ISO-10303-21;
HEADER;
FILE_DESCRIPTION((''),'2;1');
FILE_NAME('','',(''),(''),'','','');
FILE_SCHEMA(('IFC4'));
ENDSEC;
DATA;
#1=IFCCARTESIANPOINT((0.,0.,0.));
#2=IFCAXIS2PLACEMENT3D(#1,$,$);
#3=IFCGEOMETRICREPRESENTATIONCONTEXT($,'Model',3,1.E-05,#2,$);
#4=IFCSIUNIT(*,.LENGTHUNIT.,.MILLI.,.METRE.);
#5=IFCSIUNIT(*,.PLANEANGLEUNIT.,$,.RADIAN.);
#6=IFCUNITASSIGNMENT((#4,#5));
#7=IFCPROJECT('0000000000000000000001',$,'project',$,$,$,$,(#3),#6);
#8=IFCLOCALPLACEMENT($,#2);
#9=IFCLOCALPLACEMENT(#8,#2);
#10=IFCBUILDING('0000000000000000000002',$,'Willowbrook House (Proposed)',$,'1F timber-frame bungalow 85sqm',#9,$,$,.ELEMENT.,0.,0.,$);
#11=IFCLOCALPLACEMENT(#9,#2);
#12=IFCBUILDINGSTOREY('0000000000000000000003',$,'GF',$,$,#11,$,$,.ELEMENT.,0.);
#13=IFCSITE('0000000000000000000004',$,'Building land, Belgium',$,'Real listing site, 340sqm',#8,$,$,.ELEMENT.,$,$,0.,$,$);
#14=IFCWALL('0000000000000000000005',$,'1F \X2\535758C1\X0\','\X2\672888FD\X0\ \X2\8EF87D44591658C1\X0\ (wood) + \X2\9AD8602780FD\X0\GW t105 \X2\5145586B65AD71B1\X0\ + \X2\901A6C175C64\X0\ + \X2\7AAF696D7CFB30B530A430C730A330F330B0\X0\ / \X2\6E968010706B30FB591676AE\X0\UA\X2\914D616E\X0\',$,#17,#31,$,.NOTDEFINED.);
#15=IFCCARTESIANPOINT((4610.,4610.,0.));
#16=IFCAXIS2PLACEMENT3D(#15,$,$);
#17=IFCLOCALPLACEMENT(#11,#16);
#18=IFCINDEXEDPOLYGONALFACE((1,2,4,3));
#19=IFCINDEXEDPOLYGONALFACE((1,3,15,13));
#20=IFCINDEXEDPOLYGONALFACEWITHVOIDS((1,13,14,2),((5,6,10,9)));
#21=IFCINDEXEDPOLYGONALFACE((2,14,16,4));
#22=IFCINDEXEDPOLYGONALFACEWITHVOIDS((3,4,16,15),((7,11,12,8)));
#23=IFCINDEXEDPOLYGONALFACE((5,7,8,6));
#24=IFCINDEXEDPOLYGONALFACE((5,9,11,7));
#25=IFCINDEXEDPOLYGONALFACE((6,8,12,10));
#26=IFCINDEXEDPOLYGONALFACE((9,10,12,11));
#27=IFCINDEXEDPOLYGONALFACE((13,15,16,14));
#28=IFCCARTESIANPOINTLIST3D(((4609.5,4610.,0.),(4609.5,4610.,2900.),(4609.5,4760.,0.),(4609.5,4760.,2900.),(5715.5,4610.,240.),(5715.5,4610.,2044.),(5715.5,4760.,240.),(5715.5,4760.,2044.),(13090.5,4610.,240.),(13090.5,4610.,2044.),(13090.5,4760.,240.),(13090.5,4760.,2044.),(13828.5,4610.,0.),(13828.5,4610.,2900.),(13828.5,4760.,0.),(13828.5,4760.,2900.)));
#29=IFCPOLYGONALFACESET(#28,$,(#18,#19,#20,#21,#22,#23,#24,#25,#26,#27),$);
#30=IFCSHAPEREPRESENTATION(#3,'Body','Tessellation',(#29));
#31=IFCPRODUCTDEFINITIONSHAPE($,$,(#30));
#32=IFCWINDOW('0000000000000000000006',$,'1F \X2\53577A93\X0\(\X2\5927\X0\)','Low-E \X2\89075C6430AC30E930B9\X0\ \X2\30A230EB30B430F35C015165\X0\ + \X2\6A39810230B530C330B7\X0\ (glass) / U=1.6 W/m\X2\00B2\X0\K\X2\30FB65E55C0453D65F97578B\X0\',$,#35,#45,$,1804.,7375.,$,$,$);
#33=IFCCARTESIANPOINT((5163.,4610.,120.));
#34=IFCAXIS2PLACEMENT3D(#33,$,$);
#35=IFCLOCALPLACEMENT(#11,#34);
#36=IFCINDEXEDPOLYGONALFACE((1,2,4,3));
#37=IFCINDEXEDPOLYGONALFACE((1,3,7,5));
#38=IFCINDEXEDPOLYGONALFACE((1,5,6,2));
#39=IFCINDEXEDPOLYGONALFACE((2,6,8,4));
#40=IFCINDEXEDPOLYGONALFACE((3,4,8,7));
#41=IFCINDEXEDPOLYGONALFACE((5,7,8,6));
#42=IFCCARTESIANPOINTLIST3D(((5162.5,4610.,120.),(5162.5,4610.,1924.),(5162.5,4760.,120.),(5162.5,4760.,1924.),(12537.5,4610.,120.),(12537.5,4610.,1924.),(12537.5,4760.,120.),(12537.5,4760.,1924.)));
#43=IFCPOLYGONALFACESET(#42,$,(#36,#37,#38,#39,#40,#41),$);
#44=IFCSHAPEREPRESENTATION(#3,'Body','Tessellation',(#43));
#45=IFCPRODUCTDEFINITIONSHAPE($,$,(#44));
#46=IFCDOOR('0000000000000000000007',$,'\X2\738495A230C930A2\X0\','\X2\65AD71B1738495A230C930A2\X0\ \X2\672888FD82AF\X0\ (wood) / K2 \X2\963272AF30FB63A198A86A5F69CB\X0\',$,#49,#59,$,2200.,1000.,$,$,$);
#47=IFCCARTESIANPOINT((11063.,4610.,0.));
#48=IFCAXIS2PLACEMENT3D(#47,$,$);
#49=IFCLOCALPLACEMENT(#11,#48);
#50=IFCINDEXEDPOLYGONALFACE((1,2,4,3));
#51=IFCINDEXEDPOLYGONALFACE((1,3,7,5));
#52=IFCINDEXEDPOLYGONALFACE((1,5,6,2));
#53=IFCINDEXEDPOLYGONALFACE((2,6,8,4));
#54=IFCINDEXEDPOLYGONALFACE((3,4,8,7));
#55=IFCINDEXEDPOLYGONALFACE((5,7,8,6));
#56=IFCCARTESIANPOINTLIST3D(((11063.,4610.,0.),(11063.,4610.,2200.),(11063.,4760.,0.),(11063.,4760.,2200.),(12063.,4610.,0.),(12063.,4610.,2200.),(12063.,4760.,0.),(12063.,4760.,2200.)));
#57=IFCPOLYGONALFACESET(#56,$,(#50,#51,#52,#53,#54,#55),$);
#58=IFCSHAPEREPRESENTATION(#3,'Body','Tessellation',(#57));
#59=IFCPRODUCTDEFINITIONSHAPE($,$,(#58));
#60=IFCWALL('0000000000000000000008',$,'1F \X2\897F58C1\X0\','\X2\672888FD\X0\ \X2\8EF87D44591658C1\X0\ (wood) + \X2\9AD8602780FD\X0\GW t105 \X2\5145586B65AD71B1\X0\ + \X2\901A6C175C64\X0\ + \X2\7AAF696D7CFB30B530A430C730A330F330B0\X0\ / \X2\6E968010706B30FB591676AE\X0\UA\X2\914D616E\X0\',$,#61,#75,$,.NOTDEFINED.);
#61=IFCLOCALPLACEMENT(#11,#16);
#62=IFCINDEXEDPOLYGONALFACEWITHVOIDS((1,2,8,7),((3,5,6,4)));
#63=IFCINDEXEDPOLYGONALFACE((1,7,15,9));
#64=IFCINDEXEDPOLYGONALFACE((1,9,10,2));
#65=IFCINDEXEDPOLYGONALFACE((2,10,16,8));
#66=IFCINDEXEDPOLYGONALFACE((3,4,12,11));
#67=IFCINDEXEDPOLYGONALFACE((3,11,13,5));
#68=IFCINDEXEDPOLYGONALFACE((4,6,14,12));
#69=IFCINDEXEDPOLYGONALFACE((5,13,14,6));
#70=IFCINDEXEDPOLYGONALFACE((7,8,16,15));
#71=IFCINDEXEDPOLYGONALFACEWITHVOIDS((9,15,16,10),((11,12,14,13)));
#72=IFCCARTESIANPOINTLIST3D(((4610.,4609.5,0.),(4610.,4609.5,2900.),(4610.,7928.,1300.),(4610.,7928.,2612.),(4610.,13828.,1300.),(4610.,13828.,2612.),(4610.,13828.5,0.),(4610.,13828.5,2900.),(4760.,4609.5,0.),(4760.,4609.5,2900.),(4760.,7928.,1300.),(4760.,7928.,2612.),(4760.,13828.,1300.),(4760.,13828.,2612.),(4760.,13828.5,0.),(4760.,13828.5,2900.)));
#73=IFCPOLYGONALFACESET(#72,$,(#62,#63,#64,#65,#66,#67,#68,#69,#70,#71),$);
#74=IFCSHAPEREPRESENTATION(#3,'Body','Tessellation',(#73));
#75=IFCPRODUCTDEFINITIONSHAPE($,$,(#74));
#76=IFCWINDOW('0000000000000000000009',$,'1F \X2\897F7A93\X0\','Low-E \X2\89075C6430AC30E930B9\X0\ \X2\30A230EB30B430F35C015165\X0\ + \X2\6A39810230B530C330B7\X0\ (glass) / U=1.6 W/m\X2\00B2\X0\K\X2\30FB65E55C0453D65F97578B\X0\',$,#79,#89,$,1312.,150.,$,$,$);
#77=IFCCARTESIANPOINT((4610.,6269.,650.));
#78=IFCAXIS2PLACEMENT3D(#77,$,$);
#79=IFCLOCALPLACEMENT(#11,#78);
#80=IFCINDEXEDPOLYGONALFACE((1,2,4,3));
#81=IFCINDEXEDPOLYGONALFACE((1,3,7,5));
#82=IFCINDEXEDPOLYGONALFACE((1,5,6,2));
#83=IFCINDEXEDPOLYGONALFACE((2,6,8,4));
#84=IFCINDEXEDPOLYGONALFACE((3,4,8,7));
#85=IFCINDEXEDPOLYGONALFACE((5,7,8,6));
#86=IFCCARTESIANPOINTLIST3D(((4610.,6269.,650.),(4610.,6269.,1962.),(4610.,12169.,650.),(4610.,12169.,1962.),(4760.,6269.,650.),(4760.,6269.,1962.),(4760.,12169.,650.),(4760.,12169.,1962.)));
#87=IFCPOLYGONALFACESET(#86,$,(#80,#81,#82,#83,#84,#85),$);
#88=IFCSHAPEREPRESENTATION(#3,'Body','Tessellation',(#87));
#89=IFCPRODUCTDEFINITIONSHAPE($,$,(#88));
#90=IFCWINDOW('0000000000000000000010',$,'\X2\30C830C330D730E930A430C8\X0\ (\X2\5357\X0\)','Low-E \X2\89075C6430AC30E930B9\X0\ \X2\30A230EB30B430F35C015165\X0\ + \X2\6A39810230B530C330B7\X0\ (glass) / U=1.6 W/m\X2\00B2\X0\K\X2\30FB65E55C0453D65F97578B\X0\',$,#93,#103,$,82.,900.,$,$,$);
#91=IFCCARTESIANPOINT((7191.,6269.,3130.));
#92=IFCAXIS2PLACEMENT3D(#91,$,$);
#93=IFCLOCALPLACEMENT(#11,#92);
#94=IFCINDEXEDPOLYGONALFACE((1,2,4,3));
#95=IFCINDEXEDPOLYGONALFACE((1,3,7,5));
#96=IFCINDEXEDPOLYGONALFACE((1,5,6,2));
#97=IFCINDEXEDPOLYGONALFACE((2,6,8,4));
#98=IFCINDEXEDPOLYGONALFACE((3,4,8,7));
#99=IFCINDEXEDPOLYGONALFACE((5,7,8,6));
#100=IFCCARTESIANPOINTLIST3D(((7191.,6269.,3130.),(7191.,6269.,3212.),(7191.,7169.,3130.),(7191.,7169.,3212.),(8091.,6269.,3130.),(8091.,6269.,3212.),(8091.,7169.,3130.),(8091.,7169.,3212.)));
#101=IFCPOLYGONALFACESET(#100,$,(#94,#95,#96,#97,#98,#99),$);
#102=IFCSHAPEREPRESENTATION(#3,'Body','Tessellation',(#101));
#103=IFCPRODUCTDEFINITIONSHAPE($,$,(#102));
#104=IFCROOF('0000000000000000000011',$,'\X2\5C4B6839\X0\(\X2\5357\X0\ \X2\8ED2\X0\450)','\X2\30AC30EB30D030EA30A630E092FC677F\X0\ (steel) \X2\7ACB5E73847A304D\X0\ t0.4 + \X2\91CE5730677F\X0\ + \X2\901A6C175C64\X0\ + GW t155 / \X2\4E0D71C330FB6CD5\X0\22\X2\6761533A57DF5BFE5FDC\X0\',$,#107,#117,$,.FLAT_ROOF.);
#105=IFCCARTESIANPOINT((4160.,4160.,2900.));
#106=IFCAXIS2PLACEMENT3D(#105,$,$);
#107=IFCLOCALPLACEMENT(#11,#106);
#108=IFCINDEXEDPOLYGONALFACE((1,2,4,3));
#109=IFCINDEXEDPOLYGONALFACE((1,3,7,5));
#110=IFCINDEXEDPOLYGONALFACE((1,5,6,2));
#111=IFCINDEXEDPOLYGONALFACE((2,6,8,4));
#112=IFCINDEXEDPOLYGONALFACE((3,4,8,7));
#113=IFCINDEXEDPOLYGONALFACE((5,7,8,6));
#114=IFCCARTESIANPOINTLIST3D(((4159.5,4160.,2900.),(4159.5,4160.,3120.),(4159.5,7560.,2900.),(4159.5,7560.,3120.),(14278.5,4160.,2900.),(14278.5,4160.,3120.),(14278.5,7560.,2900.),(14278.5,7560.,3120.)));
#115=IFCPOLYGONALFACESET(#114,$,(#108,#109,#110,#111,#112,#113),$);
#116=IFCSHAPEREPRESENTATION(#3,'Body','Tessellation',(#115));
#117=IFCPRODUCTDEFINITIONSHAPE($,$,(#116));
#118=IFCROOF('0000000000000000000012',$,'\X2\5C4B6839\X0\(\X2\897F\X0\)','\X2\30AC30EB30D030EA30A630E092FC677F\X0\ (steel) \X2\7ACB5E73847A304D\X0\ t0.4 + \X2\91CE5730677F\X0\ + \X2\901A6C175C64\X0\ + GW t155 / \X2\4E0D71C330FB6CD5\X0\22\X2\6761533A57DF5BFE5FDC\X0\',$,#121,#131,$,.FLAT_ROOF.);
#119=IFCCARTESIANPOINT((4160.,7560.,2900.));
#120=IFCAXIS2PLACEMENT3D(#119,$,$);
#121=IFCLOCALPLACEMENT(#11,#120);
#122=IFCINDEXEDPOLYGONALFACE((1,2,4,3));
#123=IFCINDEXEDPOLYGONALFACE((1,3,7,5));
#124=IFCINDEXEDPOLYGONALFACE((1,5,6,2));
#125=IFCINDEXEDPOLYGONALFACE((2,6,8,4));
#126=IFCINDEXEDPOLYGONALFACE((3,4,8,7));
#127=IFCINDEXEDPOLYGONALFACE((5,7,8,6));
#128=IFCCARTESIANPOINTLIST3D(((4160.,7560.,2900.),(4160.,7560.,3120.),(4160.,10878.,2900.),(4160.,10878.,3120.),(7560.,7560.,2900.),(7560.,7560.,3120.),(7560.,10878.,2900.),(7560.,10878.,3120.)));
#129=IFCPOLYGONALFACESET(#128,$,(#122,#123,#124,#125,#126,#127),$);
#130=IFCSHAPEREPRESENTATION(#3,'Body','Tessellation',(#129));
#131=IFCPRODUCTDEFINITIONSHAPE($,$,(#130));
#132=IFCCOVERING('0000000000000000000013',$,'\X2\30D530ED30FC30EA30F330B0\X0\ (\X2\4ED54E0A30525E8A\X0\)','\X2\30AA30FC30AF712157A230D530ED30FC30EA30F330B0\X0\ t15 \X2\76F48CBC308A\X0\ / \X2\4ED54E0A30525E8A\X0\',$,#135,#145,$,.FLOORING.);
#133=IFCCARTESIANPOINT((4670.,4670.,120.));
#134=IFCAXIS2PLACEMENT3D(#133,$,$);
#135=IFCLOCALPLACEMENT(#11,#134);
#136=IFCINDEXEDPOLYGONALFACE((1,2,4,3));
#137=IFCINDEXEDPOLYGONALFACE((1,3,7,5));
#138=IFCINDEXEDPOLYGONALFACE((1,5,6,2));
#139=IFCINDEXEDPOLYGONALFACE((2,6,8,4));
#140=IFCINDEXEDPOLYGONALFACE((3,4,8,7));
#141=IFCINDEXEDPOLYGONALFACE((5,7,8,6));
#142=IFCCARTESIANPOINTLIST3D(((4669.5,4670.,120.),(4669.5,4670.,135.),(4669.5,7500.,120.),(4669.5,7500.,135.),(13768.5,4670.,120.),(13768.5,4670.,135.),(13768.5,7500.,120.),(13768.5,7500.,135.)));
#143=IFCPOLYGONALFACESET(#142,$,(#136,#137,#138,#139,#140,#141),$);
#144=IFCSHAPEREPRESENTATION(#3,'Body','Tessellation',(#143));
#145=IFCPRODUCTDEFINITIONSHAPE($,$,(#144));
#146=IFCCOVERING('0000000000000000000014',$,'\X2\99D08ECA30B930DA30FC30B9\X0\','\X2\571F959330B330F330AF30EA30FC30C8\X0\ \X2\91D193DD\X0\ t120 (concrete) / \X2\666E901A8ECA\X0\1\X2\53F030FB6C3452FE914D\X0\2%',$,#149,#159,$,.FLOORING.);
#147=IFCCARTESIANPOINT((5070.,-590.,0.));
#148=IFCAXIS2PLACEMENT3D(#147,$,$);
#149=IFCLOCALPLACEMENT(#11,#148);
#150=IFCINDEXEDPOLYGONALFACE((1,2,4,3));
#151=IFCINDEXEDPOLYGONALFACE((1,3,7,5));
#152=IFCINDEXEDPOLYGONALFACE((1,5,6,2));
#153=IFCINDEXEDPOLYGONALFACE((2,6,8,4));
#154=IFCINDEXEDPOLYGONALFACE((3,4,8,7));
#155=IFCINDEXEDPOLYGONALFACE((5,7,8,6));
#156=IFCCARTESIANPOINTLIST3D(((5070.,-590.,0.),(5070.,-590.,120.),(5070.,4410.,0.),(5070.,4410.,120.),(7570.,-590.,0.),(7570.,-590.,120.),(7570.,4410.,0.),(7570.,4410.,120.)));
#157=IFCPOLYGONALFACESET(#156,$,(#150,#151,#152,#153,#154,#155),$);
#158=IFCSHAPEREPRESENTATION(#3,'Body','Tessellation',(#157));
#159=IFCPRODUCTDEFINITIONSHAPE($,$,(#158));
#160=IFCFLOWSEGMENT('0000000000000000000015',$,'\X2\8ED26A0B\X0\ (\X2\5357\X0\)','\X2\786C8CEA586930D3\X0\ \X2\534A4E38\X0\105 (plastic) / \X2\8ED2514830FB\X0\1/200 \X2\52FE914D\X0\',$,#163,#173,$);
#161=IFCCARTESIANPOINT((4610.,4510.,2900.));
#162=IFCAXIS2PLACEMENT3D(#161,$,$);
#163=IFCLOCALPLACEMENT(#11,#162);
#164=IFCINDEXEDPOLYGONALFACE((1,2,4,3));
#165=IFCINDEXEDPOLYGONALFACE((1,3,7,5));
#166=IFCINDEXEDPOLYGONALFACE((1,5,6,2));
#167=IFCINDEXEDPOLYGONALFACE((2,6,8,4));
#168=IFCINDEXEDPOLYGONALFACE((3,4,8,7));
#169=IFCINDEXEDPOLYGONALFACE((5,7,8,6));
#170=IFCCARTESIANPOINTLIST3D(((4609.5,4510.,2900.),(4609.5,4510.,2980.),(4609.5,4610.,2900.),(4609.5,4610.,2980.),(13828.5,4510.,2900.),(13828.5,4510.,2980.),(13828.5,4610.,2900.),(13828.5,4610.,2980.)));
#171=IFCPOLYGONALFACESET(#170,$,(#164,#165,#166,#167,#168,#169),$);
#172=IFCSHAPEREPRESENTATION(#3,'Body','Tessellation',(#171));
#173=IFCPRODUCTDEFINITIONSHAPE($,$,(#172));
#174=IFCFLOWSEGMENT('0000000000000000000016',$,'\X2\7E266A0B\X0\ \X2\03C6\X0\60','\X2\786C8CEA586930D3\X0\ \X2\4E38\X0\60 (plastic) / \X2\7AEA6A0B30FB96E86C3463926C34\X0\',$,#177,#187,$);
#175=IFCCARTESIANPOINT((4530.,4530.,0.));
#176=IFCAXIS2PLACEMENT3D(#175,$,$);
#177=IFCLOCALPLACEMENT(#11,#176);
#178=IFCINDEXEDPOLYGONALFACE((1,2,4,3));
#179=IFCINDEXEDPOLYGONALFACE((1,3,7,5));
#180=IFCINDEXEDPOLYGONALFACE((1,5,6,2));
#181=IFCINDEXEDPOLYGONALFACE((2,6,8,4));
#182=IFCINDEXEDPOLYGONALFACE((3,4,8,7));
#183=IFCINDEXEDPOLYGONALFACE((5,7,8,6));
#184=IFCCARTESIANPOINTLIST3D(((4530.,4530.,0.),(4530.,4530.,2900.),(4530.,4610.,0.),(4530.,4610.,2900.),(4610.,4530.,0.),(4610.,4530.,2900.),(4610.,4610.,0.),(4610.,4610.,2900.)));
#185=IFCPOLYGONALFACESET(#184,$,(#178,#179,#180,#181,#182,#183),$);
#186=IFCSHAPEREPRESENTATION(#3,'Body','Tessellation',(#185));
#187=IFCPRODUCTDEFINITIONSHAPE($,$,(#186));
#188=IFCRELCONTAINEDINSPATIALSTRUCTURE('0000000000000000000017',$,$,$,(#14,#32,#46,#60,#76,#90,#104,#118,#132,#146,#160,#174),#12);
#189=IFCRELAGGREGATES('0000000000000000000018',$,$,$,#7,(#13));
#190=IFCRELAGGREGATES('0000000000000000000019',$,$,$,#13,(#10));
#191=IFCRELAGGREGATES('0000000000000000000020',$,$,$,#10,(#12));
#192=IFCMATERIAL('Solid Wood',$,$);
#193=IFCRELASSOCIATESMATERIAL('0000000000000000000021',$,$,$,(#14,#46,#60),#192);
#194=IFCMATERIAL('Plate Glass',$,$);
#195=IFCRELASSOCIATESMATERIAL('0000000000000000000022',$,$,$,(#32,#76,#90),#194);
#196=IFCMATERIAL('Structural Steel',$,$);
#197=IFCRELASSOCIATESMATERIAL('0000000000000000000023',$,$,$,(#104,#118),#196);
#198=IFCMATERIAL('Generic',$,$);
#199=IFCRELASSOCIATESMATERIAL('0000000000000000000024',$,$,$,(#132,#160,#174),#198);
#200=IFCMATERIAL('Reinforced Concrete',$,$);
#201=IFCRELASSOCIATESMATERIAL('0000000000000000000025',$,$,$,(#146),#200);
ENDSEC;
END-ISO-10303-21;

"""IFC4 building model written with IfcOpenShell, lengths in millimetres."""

from ifc_helpers import new_model, si_unit, frame, frame_2d, origin, place, context, project, spatial, rectangle, extrude, material, element, fill, save


model = new_model("IFC4")

# Units and contexts
model_context = context("Model", 3, precision=1e-05, world=origin())
ifc_project = project(units=[si_unit("LENGTHUNIT", "METRE", prefix="MILLI"), si_unit("PLANEANGLEUNIT", "RADIAN")], contexts=[model_context])

# Site, building, storey
site_placement = place(None, origin())
site = spatial("IfcSite", under=ifc_project, at=site_placement, Name="Building land, Belgium", ObjectType="Real listing site, 340sqm", CompositionType="ELEMENT", RefElevation=0.0)
building_placement = place(site_placement, origin())
building = spatial("IfcBuilding", under=site, at=building_placement, Name="Willowbrook House (Proposed)", ObjectType="1F timber-frame bungalow 85sqm", CompositionType="ELEMENT", ElevationOfRefHeight=0.0, ElevationOfTerrain=0.0)
storey_placement = place(building_placement, origin())
storey = spatial("IfcBuildingStorey", under=building, at=storey_placement, Name="GF", CompositionType="ELEMENT", Elevation=0.0)

# Shared definitions
ifc_material_1 = material(Name="Solid Wood")

# Shared definitions
ifc_material_2 = material(Name="Reinforced Concrete")

# Wall, openings, window, door
wall_1_placement = place(storey_placement, frame((4610.0, 4610.0, 0.0)))
wall_1 = element("IfcWall", 1, at=wall_1_placement, inside=storey, material=ifc_material_1, Name="1F 南壁", Description="木製 軸組外壁 (wood) + 高性能GW t105 充填断熱 + 通気層 + 窯業系サイディング / 準耐火・外皮UA配慮", PredefinedType="NOTDEFINED", context=model_context, shape_type="SweptSolid", body=[
    extrude(rectangle(XDim=9219.0, YDim=150.0, at=frame_2d((4609.0, 75.0))), frame((4610.0, 4610.0, 0.0)), (0.0, 0.0, 1.0), 2900.0),
])
opening_1_placement = place(storey_placement, frame((5163.0, 4610.0, 120.0)))
opening_1 = element("IfcOpeningElement", 2, at=opening_1_placement, cuts=wall_1, PredefinedType="NOTDEFINED", context=model_context, shape_type="SweptSolid", body=[
    extrude(rectangle(XDim=7375.0, YDim=150.0, at=frame_2d((3687.0, 75.0))), frame((5163.0, 4610.0, 120.0)), (0.0, 0.0, 1.0), 1804.0),
])
opening_2_placement = place(storey_placement, frame((11063.0, 4610.0, 0.0)))
opening_2 = element("IfcOpeningElement", 3, at=opening_2_placement, cuts=wall_1, PredefinedType="NOTDEFINED", context=model_context, shape_type="SweptSolid", body=[
    extrude(rectangle(XDim=1000.0, YDim=150.0, at=frame_2d((500.0, 75.0))), frame((11063.0, 4610.0, 0.0)), (0.0, 0.0, 1.0), 2200.0),
])
ifc_material_3 = material(Name="Plate Glass")
window_1_placement = place(storey_placement, frame((5163.0, 4610.0, 120.0)))
window_1 = element("IfcWindow", 4, at=window_1_placement, inside=storey, material=ifc_material_3, Name="1F 南窓(大)", Description="Low-E 複層ガラス アルゴン封入 + 樹脂サッシ (glass) / U=1.6 W/m²K・日射取得型", OverallHeight=1804.0, OverallWidth=7375.0, context=model_context, shape_type="SweptSolid", body=[
    extrude(rectangle(XDim=7375.0, YDim=150.0, at=frame_2d((3687.0, 75.0))), frame((5163.0, 4610.0, 120.0)), (0.0, 0.0, 1.0), 1804.0),
])
fill(opening_1, window_1)
door_placement = place(storey_placement, frame((11063.0, 4610.0, 0.0)))
door = element("IfcDoor", 5, at=door_placement, inside=storey, material=ifc_material_1, Name="玄関ドア", Description="断熱玄関ドア 木製芯 (wood) / K2 防犯・採風機構", OverallHeight=2200.0, OverallWidth=1000.0, context=model_context, shape_type="SweptSolid", body=[
    extrude(rectangle(XDim=1000.0, YDim=150.0, at=frame_2d((500.0, 75.0))), frame((11063.0, 4610.0, 0.0)), (0.0, 0.0, 1.0), 2200.0),
])
fill(opening_2, door)

# Wall, opening, window
wall_2_placement = place(storey_placement, frame((4610.0, 4610.0, 0.0)))
wall_2 = element("IfcWall", 6, at=wall_2_placement, inside=storey, material=ifc_material_1, Name="1F 西壁", Description="木製 軸組外壁 (wood) + 高性能GW t105 充填断熱 + 通気層 + 窯業系サイディング / 準耐火・外皮UA配慮", PredefinedType="NOTDEFINED", context=model_context, shape_type="SweptSolid", body=[
    extrude(rectangle(XDim=150.0, YDim=9219.0, at=frame_2d((75.0, 4609.0))), frame((4610.0, 4610.0, 0.0)), (0.0, 0.0, 1.0), 2900.0),
])
opening_3_placement = place(storey_placement, frame((4610.0, 6269.0, 650.0)))
opening_3 = element("IfcOpeningElement", 7, at=opening_3_placement, cuts=wall_2, PredefinedType="NOTDEFINED", context=model_context, shape_type="SweptSolid", body=[
    extrude(rectangle(XDim=150.0, YDim=5900.0, at=frame_2d((75.0, 2950.0))), frame((4610.0, 6269.0, 650.0)), (0.0, 0.0, 1.0), 1312.0),
])
window_2_placement = place(storey_placement, frame((4610.0, 6269.0, 650.0)))
window_2 = element("IfcWindow", 8, at=window_2_placement, inside=storey, material=ifc_material_3, Name="1F 西窓", Description="Low-E 複層ガラス アルゴン封入 + 樹脂サッシ (glass) / U=1.6 W/m²K・日射取得型", OverallHeight=1312.0, OverallWidth=150.0, context=model_context, shape_type="SweptSolid", body=[
    extrude(rectangle(XDim=150.0, YDim=5900.0, at=frame_2d((75.0, 2950.0))), frame((4610.0, 6269.0, 650.0)), (0.0, 0.0, 1.0), 1312.0),
])
fill(opening_3, window_2)

# Window
window_3_placement = place(storey_placement, frame((7191.0, 6269.0, 3130.0)))
element("IfcWindow", 9, at=window_3_placement, inside=storey, material=ifc_material_3, Name="トップライト (南)", Description="Low-E 複層ガラス アルゴン封入 + 樹脂サッシ (glass) / U=1.6 W/m²K・日射取得型", OverallHeight=82.0, OverallWidth=900.0, context=model_context, shape_type="SweptSolid", body=[
    extrude(rectangle(XDim=900.0, YDim=900.0, at=frame_2d((450.0, 450.0))), frame((7191.0, 6269.0, 3130.0)), (0.0, 0.0, 1.0), 82.0),
])

# Roofs
ifc_material_4 = material(Name="Structural Steel")
roof_1_placement = place(storey_placement, frame((4160.0, 4160.0, 2900.0)))
element("IfcRoof", 10, at=roof_1_placement, inside=storey, material=ifc_material_4, Name="屋根(南 軒450)", Description="ガルバリウム鋼板 (steel) 立平葺き t0.4 + 野地板 + 通気層 + GW t155 / 不燃・法22条区域対応", PredefinedType="FLAT_ROOF", context=model_context, shape_type="SweptSolid", body=[
    extrude(rectangle(XDim=10119.0, YDim=3400.0, at=frame_2d((5059.0, 1700.0))), frame((4160.0, 4160.0, 2900.0)), (0.0, 0.0, 1.0), 220.0),
])
roof_2_placement = place(storey_placement, frame((4160.0, 7560.0, 2900.0)))
element("IfcRoof", 11, at=roof_2_placement, inside=storey, material=ifc_material_4, Name="屋根(西)", Description="ガルバリウム鋼板 (steel) 立平葺き t0.4 + 野地板 + 通気層 + GW t155 / 不燃・法22条区域対応", PredefinedType="FLAT_ROOF", context=model_context, shape_type="SweptSolid", body=[
    extrude(rectangle(XDim=3400.0, YDim=3318.0, at=frame_2d((1700.0, 1659.0))), frame((4160.0, 7560.0, 2900.0)), (0.0, 0.0, 1.0), 220.0),
])

# Coverings
ifc_material_5 = material(Name="Generic")
covering_1_placement = place(storey_placement, frame((4670.0, 4670.0, 120.0)))
element("IfcCovering", 12, at=covering_1_placement, inside=storey, material=ifc_material_5, Name="フローリング (仕上げ床)", Description="オーク無垢フローリング t15 直貼り / 仕上げ床", PredefinedType="FLOORING", context=model_context, shape_type="SweptSolid", body=[
    extrude(rectangle(XDim=9099.0, YDim=2830.0, at=frame_2d((4549.0, 1415.0))), frame((4670.0, 4670.0, 120.0)), (0.0, 0.0, 1.0), 15.0),
])
covering_2_placement = place(storey_placement, frame((5070.0, -590.0, 0.0)))
element("IfcCovering", 13, at=covering_2_placement, inside=storey, material=ifc_material_2, Name="駐車スペース", Description="土間コンクリート 金鏝 t120 (concrete) / 普通車1台・水勾配2%", PredefinedType="FLOORING", context=model_context, shape_type="SweptSolid", body=[
    extrude(rectangle(XDim=2500.0, YDim=5000.0, at=frame_2d((1250.0, 2500.0))), frame((5070.0, -590.0, 0.0)), (0.0, 0.0, 1.0), 120.0),
])

# Flow segments
flow_segment_1_placement = place(storey_placement, frame((4610.0, 4510.0, 2900.0)))
element("IfcFlowSegment", 14, at=flow_segment_1_placement, inside=storey, material=ifc_material_5, Name="軒樋 (南)", Description="硬質塩ビ 半丸105 (plastic) / 軒先・1/200 勾配", context=model_context, shape_type="SweptSolid", body=[
    extrude(rectangle(XDim=9219.0, YDim=100.0, at=frame_2d((4609.0, 50.0))), frame((4610.0, 4510.0, 2900.0)), (0.0, 0.0, 1.0), 80.0),
])
flow_segment_2_placement = place(storey_placement, frame((4530.0, 4530.0, 0.0)))
element("IfcFlowSegment", 15, at=flow_segment_2_placement, inside=storey, material=ifc_material_5, Name="縦樋 φ60", Description="硬質塩ビ 丸60 (plastic) / 竪樋・雨水排水", context=model_context, shape_type="SweptSolid", body=[
    extrude(rectangle(XDim=80.0, YDim=80.0, at=frame_2d((40.0, 40.0))), frame((4530.0, 4530.0, 0.0)), (0.0, 0.0, 1.0), 2900.0),
])

save(model, "model.ifc")
